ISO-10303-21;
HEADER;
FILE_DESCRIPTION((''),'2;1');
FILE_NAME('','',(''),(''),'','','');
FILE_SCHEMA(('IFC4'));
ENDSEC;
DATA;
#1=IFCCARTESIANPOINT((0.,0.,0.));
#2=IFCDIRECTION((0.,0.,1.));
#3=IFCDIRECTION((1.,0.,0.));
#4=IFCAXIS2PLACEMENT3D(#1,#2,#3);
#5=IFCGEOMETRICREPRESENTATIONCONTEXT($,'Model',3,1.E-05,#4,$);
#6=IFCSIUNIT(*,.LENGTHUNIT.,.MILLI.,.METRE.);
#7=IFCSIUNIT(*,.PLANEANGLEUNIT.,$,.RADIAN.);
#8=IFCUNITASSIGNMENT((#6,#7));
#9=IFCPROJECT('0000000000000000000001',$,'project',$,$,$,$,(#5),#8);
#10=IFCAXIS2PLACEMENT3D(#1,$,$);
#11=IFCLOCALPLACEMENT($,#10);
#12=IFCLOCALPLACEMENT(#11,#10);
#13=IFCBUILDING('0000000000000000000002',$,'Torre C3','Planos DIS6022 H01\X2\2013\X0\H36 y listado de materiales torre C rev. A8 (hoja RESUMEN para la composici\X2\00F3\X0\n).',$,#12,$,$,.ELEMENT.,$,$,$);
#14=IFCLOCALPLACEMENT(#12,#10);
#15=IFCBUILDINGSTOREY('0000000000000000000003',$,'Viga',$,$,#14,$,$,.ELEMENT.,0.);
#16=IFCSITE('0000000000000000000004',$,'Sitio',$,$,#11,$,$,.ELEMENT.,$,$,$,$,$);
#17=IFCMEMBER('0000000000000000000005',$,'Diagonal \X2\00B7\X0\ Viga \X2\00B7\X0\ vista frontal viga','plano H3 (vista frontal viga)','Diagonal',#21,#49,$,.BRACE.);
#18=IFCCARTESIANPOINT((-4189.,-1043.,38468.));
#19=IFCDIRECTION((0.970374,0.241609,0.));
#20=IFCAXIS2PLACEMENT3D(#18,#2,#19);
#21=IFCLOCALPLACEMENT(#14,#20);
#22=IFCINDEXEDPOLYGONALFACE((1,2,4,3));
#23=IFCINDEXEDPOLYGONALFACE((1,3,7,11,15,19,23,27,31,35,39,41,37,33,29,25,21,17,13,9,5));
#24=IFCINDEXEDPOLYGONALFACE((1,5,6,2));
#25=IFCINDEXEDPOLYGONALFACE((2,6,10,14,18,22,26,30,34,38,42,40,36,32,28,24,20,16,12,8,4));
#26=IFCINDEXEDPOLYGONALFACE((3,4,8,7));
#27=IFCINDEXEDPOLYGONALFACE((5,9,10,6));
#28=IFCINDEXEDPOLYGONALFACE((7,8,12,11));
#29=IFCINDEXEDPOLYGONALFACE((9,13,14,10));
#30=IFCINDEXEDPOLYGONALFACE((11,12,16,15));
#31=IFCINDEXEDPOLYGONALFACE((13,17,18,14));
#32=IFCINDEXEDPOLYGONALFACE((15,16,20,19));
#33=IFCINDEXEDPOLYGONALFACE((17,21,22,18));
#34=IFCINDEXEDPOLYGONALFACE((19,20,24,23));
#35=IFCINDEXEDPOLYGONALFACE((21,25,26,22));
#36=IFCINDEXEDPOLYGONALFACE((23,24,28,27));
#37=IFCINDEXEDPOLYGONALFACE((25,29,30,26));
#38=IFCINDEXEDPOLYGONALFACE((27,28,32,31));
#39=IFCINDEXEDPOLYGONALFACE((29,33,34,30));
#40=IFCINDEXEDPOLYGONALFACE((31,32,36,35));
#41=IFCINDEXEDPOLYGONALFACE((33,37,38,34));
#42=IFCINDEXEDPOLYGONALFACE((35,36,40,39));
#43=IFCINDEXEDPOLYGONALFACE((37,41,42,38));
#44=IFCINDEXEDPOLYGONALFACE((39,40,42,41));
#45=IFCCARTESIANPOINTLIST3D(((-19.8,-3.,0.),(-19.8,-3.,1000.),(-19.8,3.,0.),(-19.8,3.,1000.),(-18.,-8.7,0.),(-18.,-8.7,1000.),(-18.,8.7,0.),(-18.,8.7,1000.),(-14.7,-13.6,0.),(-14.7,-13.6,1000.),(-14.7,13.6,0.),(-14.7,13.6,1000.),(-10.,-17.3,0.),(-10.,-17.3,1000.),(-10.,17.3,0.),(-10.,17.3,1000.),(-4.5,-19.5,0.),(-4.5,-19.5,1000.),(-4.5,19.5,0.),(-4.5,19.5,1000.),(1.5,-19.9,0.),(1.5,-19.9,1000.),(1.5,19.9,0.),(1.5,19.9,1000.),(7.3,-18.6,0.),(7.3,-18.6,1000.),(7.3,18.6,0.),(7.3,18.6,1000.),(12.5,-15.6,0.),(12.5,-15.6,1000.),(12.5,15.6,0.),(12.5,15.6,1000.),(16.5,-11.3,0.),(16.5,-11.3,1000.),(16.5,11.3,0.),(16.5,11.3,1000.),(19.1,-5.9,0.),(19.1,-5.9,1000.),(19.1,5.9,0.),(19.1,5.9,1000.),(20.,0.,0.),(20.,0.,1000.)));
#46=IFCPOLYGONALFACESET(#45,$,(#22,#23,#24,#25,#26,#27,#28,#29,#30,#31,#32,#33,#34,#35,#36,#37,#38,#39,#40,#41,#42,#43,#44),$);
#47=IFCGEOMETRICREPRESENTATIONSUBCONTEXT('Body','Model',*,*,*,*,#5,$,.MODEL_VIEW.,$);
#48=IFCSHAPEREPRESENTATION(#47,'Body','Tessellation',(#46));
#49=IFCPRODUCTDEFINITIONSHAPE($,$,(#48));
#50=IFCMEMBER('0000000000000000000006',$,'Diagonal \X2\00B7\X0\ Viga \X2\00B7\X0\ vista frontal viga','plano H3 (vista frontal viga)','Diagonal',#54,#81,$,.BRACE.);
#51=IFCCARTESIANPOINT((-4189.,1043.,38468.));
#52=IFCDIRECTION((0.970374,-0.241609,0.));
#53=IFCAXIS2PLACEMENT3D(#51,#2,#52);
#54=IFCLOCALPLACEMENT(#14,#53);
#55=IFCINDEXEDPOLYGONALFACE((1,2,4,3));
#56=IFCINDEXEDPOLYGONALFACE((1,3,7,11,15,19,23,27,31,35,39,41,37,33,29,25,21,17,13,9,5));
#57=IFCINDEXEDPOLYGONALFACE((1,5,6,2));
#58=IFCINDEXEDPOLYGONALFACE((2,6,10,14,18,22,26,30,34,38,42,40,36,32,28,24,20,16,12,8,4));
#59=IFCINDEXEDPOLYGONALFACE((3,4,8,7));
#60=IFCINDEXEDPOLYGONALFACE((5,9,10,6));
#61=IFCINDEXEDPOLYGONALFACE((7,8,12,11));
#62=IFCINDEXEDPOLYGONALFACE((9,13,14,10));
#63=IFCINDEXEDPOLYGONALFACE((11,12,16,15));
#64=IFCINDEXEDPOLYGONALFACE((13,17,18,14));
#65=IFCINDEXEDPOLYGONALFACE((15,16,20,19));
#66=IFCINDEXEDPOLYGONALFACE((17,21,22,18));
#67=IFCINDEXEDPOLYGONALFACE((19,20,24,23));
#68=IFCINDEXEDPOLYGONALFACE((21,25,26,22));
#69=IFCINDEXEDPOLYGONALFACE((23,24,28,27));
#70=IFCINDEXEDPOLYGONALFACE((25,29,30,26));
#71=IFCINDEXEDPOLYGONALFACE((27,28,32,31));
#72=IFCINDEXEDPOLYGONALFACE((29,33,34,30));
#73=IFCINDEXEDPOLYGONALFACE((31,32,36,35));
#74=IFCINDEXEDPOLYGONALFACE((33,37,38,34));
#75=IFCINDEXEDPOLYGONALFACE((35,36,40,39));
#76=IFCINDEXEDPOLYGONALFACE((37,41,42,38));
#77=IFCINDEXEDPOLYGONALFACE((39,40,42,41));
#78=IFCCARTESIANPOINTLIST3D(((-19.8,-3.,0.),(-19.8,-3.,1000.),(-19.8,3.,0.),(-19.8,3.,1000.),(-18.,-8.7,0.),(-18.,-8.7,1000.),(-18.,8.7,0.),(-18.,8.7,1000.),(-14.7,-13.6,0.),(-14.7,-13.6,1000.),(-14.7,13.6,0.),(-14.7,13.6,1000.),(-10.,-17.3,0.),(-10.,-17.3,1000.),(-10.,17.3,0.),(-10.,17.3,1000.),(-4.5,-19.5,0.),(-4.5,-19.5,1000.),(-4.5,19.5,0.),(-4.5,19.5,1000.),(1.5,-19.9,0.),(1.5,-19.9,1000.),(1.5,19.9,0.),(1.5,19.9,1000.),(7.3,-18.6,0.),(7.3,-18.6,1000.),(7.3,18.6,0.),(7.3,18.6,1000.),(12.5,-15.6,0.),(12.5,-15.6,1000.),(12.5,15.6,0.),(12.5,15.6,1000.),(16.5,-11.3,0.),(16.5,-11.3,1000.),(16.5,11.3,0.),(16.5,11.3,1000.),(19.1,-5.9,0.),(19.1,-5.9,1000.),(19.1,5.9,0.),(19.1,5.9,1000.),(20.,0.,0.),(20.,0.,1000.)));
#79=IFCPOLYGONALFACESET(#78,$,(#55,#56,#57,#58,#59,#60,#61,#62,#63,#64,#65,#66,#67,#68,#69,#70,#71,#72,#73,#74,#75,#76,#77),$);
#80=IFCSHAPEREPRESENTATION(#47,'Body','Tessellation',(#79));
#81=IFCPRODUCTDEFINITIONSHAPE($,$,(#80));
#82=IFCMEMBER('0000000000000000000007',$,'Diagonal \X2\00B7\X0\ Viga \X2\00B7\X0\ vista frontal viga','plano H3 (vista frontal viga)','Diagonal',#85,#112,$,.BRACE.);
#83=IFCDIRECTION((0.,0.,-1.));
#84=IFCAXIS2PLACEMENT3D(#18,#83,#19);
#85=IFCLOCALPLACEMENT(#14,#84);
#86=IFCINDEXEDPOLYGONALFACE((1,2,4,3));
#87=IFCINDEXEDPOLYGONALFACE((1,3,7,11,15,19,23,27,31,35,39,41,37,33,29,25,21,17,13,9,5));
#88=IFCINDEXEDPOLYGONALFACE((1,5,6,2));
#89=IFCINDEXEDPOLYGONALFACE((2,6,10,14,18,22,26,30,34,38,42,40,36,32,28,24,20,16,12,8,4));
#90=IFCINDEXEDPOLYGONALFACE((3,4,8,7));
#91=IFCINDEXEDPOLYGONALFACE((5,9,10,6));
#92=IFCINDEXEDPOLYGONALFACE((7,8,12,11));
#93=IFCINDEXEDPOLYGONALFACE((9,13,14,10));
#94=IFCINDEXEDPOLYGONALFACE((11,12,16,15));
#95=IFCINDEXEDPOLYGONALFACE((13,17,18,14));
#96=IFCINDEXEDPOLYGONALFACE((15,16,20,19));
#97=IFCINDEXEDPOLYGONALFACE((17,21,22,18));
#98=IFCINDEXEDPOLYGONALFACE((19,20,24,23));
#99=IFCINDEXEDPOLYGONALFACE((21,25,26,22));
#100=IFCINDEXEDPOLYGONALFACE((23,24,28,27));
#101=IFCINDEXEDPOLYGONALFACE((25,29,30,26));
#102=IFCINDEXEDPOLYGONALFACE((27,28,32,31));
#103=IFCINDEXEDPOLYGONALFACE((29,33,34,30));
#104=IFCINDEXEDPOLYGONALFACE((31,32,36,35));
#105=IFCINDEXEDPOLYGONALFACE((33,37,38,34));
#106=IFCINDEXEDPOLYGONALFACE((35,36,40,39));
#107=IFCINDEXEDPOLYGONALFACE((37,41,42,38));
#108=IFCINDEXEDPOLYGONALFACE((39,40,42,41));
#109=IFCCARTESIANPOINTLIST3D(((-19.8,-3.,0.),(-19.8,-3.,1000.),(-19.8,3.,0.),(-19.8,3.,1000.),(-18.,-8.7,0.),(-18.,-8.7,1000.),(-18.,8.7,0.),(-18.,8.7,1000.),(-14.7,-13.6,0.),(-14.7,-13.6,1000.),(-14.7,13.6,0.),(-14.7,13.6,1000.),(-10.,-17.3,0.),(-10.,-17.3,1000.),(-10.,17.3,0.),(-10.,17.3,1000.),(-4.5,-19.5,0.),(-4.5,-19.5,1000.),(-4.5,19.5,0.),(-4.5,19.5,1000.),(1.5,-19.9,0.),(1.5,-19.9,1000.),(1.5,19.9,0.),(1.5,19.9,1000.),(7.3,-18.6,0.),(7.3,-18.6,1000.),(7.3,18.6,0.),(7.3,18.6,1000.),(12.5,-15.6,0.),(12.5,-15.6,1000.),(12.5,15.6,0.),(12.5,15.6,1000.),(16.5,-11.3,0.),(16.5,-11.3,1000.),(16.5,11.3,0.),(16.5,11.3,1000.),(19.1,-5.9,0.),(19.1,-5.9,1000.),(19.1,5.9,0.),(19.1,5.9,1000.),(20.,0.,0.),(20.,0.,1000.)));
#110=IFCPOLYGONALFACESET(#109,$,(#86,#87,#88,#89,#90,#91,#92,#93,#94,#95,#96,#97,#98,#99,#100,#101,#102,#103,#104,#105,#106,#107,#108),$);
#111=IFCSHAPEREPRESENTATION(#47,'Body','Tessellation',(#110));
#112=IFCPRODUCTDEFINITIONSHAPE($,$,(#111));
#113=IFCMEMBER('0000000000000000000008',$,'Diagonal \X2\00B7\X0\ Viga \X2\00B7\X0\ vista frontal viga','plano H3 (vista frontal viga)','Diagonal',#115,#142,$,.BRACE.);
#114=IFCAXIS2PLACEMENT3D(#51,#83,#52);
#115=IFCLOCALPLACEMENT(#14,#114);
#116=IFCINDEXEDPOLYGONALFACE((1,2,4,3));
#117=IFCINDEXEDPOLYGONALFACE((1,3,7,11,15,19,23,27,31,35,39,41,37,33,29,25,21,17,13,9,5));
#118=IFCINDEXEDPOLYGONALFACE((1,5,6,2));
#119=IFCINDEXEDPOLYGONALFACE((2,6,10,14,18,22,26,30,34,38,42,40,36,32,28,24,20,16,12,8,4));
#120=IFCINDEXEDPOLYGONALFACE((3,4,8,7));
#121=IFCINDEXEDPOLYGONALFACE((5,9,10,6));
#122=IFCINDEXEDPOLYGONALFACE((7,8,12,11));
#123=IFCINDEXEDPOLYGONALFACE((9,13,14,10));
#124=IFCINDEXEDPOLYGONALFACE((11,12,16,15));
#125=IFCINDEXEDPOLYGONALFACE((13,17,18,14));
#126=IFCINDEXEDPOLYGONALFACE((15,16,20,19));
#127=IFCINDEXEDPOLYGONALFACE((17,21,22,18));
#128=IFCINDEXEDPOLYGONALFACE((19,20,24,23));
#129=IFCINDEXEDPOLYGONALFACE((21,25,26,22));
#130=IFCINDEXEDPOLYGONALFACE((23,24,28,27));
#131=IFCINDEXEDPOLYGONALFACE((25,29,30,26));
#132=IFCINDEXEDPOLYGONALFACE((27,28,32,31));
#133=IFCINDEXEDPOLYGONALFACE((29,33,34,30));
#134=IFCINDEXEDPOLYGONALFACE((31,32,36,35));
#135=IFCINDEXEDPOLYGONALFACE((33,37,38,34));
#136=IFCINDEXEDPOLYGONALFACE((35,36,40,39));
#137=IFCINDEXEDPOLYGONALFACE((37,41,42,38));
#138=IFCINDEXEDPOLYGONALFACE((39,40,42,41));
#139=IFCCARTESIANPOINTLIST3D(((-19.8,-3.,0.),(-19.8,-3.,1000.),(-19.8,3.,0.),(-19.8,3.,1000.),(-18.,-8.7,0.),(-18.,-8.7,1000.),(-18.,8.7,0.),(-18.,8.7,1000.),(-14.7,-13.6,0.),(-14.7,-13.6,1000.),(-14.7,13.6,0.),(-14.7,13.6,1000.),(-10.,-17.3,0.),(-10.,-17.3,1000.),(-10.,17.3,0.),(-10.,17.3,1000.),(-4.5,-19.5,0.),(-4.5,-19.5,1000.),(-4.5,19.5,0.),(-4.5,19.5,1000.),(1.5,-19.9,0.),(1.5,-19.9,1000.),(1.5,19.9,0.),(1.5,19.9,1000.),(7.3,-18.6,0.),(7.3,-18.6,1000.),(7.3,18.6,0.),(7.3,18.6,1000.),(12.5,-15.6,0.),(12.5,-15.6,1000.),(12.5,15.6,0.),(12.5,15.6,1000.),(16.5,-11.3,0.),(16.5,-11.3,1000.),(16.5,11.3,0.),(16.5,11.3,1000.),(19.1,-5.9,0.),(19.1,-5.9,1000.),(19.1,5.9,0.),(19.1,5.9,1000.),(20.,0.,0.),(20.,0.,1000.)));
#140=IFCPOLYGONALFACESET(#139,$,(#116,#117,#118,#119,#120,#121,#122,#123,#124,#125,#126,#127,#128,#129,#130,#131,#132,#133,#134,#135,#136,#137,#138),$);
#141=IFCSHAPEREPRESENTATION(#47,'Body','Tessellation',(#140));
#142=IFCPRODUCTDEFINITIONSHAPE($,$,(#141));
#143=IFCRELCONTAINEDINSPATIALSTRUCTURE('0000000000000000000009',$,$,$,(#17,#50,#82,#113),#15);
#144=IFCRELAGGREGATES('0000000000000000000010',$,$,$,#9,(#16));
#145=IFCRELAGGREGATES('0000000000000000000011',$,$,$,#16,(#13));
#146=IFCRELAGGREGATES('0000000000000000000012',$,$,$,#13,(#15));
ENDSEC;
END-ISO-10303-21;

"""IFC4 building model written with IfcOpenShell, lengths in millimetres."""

from ifc_helpers import new_model, si_unit, frame, origin, origin_with_axes, place, context, subcontext, project, spatial, circle, extrude, element, save


model = new_model("IFC4")

# Units and contexts
model_context = context("Model", 3, precision=1e-05, world=origin_with_axes())
body_context = subcontext(model_context, "Body", "Model", "MODEL_VIEW")
ifc_project = project(units=[si_unit("LENGTHUNIT", "METRE", prefix="MILLI"), si_unit("PLANEANGLEUNIT", "RADIAN")], contexts=[model_context])

# Site, building, storey
site_placement = place(None, origin())
site = spatial("IfcSite", under=ifc_project, at=site_placement, Name="Sitio", CompositionType="ELEMENT")
building_placement = place(site_placement, origin())
building = spatial("IfcBuilding", under=site, at=building_placement, Name="Torre C3", Description="Planos DIS6022 H01–H36 y listado de materiales torre C rev. A8 (hoja RESUMEN para la composición).", CompositionType="ELEMENT")
storey_placement = place(building_placement, origin())
storey = spatial("IfcBuildingStorey", under=building, at=storey_placement, Name="Viga", CompositionType="ELEMENT", Elevation=0.0)

# Members
for number, where, z_axis, x_axis, name in (
    (1, (-4189.0, -1043.0, 38468.0), (0.0, 0.0, 1.0), (0.970374, 0.241609, 0.0), "Diagonal · Viga · vista frontal viga"),
    (2, (-4189.0, 1043.0, 38468.0), (0.0, 0.0, 1.0), (0.970374, -0.241609, 0.0), "Diagonal · Viga · vista frontal viga"),
    (3, (-4189.0, -1043.0, 38468.0), (0.0, 0.0, -1.0), (0.970374, 0.241609, 0.0), "Diagonal · Viga · vista frontal viga"),
    (4, (-4189.0, 1043.0, 38468.0), (0.0, 0.0, -1.0), (0.970374, -0.241609, 0.0), "Diagonal · Viga · vista frontal viga"),
):
    element("IfcMember", number, at=place(storey_placement, frame(where, z_axis=z_axis, x_axis=x_axis)), inside=storey, Name=name, Description="plano H3 (vista frontal viga)", ObjectType="Diagonal", PredefinedType="BRACE", context=body_context, shape_type="SweptSolid", body=[
        extrude(circle(Radius=20.0), None, (0.0, 0.0, 1.0), 1000.0),
    ])

save(model, "model.ifc")
